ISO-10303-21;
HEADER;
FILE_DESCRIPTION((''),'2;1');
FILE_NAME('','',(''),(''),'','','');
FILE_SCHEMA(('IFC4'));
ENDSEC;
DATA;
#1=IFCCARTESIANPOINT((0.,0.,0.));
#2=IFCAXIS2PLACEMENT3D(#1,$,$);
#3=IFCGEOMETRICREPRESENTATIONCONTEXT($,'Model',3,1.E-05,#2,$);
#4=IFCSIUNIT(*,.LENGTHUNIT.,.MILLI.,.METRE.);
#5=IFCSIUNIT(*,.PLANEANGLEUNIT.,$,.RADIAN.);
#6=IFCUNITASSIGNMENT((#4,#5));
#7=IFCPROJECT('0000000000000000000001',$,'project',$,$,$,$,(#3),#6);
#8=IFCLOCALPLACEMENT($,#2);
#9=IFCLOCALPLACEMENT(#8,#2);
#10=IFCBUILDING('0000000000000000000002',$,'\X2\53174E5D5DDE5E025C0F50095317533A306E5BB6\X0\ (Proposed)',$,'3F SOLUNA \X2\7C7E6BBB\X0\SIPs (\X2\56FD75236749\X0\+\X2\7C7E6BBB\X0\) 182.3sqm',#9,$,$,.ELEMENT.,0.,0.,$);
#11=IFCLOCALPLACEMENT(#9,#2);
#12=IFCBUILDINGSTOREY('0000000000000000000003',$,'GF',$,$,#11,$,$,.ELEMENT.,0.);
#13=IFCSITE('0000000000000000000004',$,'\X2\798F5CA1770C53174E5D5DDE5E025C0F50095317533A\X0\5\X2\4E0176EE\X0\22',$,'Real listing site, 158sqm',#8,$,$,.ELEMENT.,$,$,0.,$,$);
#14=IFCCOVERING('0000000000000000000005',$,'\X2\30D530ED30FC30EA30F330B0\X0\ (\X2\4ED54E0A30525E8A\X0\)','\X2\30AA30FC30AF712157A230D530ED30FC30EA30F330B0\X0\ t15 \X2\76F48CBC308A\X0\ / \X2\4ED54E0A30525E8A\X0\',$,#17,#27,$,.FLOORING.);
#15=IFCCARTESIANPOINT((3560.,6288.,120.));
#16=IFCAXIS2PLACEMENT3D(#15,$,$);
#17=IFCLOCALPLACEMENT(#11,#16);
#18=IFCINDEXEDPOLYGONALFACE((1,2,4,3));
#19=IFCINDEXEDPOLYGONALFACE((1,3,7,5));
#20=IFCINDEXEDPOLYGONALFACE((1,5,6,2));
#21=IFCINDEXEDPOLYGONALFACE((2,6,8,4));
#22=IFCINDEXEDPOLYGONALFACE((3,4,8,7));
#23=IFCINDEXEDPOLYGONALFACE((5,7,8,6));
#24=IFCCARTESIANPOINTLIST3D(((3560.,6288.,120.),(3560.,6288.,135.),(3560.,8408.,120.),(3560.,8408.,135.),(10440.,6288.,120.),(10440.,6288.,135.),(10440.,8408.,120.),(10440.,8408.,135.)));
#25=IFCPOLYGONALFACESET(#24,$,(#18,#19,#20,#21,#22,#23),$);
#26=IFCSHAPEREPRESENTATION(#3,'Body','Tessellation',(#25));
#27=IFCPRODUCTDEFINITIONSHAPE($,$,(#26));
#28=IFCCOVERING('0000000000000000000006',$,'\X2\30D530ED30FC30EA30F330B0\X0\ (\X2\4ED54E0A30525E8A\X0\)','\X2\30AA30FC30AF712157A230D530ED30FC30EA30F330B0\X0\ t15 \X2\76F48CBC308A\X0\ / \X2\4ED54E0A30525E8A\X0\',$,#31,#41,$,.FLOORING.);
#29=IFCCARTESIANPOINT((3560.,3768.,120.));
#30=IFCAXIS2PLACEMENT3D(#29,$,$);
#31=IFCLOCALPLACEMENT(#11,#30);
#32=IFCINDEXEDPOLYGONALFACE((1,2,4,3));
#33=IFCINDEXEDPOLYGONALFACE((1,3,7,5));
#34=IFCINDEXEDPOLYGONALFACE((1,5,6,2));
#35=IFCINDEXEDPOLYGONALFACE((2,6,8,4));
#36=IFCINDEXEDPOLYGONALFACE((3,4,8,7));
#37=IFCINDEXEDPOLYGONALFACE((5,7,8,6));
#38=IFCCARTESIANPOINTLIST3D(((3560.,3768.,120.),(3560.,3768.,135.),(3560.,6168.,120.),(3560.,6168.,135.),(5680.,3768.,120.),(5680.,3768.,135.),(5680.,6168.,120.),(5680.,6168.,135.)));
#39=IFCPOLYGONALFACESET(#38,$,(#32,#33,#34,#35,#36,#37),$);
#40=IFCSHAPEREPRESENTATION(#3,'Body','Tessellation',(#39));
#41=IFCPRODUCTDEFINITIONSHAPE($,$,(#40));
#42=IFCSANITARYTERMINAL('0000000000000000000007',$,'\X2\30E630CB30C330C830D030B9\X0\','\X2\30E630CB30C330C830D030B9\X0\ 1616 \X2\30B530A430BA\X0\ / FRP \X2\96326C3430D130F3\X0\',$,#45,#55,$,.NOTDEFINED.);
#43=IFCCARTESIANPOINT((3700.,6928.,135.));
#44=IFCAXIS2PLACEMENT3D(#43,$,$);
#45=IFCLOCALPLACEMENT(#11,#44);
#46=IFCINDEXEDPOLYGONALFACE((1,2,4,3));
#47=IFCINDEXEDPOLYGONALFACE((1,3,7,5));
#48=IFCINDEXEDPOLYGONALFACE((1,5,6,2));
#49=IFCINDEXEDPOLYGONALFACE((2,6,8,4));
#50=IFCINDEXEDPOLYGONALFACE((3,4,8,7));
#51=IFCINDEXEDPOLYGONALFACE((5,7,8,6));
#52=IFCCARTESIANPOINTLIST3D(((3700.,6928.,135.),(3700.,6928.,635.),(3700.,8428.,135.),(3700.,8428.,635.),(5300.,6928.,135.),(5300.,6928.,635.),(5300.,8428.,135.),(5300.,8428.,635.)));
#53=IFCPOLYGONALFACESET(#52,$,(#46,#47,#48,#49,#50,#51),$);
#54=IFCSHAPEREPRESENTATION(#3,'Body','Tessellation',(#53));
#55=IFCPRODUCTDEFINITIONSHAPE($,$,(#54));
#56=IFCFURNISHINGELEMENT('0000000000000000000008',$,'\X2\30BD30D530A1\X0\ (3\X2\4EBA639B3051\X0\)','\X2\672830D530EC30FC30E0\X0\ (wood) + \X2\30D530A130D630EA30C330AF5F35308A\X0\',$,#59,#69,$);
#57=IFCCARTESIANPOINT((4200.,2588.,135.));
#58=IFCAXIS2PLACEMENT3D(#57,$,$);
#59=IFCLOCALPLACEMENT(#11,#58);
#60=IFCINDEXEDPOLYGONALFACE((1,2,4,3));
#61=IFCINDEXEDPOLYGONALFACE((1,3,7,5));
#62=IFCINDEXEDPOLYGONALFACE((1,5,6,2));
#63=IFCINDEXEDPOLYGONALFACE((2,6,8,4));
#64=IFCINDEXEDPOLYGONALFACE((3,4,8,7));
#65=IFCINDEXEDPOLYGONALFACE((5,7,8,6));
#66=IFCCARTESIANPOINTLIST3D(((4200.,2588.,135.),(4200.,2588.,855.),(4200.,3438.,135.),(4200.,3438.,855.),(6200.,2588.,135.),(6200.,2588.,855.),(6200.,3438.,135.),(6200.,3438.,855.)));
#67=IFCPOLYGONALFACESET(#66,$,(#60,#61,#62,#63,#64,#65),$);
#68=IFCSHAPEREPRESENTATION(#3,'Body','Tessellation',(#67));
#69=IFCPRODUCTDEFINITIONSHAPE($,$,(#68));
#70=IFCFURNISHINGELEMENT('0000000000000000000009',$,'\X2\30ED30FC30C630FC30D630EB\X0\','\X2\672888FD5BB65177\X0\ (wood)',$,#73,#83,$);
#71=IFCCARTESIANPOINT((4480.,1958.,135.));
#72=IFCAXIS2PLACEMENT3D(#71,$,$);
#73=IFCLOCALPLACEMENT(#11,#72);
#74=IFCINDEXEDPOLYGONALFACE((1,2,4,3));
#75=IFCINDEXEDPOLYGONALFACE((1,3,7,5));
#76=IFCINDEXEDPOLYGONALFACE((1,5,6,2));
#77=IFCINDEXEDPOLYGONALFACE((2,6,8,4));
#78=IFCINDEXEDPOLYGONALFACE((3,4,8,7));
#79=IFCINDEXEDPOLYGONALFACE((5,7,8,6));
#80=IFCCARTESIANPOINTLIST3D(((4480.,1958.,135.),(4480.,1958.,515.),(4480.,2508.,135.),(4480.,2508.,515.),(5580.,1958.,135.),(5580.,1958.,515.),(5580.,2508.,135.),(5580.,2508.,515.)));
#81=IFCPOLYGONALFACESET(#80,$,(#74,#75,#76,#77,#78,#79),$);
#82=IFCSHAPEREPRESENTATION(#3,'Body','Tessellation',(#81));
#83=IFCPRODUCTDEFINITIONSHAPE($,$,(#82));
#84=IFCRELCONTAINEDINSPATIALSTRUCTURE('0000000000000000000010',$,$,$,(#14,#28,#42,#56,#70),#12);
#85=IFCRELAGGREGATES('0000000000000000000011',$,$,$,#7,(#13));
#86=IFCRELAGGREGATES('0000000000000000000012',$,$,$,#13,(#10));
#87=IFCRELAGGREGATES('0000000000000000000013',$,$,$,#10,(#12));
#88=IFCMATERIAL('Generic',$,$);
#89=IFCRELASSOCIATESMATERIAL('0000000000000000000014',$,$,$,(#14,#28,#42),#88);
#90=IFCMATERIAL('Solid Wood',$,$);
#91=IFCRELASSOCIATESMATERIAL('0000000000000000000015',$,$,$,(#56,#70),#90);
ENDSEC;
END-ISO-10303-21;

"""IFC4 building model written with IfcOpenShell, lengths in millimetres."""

from ifc_helpers import new_model, si_unit, frame, frame_2d, origin, place, context, project, spatial, rectangle, extrude, material, element, save


model = new_model("IFC4")

# Units and contexts
model_context = context("Model", 3, precision=1e-05, world=origin())
ifc_project = project(units=[si_unit("LENGTHUNIT", "METRE", prefix="MILLI"), si_unit("PLANEANGLEUNIT", "RADIAN")], contexts=[model_context])

# Site, building, storey
site_placement = place(None, origin())
site = spatial("IfcSite", under=ifc_project, at=site_placement, Name="福岡県北九州市小倉北区5丁目22", ObjectType="Real listing site, 158sqm", CompositionType="ELEMENT", RefElevation=0.0)
building_placement = place(site_placement, origin())
building = spatial("IfcBuilding", under=site, at=building_placement, Name="北九州市小倉北区の家 (Proposed)", ObjectType="3F SOLUNA 籾殻SIPs (国産杉+籾殻) 182.3sqm", CompositionType="ELEMENT", ElevationOfRefHeight=0.0, ElevationOfTerrain=0.0)
storey_placement = place(building_placement, origin())
storey = spatial("IfcBuildingStorey", under=building, at=storey_placement, Name="GF", CompositionType="ELEMENT", Elevation=0.0)

# Shared definitions
ifc_material_1 = material(Name="Solid Wood")

# Coverings
ifc_material_2 = material(Name="Generic")
covering_1_placement = place(storey_placement, frame((3560.0, 6288.0, 120.0)))
element("IfcCovering", 1, at=covering_1_placement, inside=storey, material=ifc_material_2, Name="フローリング (仕上げ床)", Description="オーク無垢フローリング t15 直貼り / 仕上げ床", PredefinedType="FLOORING", context=model_context, shape_type="SweptSolid", body=[
    extrude(rectangle(XDim=6880.0, YDim=2120.0, at=frame_2d((3440.0, 1060.0))), frame((3560.0, 6288.0, 120.0)), (0.0, 0.0, 1.0), 15.0),
])
covering_2_placement = place(storey_placement, frame((3560.0, 3768.0, 120.0)))
element("IfcCovering", 2, at=covering_2_placement, inside=storey, material=ifc_material_2, Name="フローリング (仕上げ床)", Description="オーク無垢フローリング t15 直貼り / 仕上げ床", PredefinedType="FLOORING", context=model_context, shape_type="SweptSolid", body=[
    extrude(rectangle(XDim=2120.0, YDim=2400.0, at=frame_2d((1060.0, 1200.0))), frame((3560.0, 3768.0, 120.0)), (0.0, 0.0, 1.0), 15.0),
])

# Sanitary terminal
sanitary_terminal_placement = place(storey_placement, frame((3700.0, 6928.0, 135.0)))
element("IfcSanitaryTerminal", 3, at=sanitary_terminal_placement, inside=storey, material=ifc_material_2, Name="ユニットバス", Description="ユニットバス 1616 サイズ / FRP 防水パン", PredefinedType="NOTDEFINED", context=model_context, shape_type="SweptSolid", body=[
    extrude(rectangle(XDim=1600.0, YDim=1500.0, at=frame_2d((800.0, 750.0))), frame((3700.0, 6928.0, 135.0)), (0.0, 0.0, 1.0), 500.0),
])

# Furnishing elements
furnishing_1_placement = place(storey_placement, frame((4200.0, 2588.0, 135.0)))
element("IfcFurnishingElement", 4, at=furnishing_1_placement, inside=storey, material=ifc_material_1, Name="ソファ (3人掛け)", Description="木フレーム (wood) + ファブリック張り", context=model_context, shape_type="SweptSolid", body=[
    extrude(rectangle(XDim=2000.0, YDim=850.0, at=frame_2d((1000.0, 425.0))), frame((4200.0, 2588.0, 135.0)), (0.0, 0.0, 1.0), 720.0),
])
furnishing_2_placement = place(storey_placement, frame((4480.0, 1958.0, 135.0)))
element("IfcFurnishingElement", 5, at=furnishing_2_placement, inside=storey, material=ifc_material_1, Name="ローテーブル", Description="木製家具 (wood)", context=model_context, shape_type="SweptSolid", body=[
    extrude(rectangle(XDim=1100.0, YDim=550.0, at=frame_2d((550.0, 275.0))), frame((4480.0, 1958.0, 135.0)), (0.0, 0.0, 1.0), 380.0),
])

save(model, "model.ifc")
